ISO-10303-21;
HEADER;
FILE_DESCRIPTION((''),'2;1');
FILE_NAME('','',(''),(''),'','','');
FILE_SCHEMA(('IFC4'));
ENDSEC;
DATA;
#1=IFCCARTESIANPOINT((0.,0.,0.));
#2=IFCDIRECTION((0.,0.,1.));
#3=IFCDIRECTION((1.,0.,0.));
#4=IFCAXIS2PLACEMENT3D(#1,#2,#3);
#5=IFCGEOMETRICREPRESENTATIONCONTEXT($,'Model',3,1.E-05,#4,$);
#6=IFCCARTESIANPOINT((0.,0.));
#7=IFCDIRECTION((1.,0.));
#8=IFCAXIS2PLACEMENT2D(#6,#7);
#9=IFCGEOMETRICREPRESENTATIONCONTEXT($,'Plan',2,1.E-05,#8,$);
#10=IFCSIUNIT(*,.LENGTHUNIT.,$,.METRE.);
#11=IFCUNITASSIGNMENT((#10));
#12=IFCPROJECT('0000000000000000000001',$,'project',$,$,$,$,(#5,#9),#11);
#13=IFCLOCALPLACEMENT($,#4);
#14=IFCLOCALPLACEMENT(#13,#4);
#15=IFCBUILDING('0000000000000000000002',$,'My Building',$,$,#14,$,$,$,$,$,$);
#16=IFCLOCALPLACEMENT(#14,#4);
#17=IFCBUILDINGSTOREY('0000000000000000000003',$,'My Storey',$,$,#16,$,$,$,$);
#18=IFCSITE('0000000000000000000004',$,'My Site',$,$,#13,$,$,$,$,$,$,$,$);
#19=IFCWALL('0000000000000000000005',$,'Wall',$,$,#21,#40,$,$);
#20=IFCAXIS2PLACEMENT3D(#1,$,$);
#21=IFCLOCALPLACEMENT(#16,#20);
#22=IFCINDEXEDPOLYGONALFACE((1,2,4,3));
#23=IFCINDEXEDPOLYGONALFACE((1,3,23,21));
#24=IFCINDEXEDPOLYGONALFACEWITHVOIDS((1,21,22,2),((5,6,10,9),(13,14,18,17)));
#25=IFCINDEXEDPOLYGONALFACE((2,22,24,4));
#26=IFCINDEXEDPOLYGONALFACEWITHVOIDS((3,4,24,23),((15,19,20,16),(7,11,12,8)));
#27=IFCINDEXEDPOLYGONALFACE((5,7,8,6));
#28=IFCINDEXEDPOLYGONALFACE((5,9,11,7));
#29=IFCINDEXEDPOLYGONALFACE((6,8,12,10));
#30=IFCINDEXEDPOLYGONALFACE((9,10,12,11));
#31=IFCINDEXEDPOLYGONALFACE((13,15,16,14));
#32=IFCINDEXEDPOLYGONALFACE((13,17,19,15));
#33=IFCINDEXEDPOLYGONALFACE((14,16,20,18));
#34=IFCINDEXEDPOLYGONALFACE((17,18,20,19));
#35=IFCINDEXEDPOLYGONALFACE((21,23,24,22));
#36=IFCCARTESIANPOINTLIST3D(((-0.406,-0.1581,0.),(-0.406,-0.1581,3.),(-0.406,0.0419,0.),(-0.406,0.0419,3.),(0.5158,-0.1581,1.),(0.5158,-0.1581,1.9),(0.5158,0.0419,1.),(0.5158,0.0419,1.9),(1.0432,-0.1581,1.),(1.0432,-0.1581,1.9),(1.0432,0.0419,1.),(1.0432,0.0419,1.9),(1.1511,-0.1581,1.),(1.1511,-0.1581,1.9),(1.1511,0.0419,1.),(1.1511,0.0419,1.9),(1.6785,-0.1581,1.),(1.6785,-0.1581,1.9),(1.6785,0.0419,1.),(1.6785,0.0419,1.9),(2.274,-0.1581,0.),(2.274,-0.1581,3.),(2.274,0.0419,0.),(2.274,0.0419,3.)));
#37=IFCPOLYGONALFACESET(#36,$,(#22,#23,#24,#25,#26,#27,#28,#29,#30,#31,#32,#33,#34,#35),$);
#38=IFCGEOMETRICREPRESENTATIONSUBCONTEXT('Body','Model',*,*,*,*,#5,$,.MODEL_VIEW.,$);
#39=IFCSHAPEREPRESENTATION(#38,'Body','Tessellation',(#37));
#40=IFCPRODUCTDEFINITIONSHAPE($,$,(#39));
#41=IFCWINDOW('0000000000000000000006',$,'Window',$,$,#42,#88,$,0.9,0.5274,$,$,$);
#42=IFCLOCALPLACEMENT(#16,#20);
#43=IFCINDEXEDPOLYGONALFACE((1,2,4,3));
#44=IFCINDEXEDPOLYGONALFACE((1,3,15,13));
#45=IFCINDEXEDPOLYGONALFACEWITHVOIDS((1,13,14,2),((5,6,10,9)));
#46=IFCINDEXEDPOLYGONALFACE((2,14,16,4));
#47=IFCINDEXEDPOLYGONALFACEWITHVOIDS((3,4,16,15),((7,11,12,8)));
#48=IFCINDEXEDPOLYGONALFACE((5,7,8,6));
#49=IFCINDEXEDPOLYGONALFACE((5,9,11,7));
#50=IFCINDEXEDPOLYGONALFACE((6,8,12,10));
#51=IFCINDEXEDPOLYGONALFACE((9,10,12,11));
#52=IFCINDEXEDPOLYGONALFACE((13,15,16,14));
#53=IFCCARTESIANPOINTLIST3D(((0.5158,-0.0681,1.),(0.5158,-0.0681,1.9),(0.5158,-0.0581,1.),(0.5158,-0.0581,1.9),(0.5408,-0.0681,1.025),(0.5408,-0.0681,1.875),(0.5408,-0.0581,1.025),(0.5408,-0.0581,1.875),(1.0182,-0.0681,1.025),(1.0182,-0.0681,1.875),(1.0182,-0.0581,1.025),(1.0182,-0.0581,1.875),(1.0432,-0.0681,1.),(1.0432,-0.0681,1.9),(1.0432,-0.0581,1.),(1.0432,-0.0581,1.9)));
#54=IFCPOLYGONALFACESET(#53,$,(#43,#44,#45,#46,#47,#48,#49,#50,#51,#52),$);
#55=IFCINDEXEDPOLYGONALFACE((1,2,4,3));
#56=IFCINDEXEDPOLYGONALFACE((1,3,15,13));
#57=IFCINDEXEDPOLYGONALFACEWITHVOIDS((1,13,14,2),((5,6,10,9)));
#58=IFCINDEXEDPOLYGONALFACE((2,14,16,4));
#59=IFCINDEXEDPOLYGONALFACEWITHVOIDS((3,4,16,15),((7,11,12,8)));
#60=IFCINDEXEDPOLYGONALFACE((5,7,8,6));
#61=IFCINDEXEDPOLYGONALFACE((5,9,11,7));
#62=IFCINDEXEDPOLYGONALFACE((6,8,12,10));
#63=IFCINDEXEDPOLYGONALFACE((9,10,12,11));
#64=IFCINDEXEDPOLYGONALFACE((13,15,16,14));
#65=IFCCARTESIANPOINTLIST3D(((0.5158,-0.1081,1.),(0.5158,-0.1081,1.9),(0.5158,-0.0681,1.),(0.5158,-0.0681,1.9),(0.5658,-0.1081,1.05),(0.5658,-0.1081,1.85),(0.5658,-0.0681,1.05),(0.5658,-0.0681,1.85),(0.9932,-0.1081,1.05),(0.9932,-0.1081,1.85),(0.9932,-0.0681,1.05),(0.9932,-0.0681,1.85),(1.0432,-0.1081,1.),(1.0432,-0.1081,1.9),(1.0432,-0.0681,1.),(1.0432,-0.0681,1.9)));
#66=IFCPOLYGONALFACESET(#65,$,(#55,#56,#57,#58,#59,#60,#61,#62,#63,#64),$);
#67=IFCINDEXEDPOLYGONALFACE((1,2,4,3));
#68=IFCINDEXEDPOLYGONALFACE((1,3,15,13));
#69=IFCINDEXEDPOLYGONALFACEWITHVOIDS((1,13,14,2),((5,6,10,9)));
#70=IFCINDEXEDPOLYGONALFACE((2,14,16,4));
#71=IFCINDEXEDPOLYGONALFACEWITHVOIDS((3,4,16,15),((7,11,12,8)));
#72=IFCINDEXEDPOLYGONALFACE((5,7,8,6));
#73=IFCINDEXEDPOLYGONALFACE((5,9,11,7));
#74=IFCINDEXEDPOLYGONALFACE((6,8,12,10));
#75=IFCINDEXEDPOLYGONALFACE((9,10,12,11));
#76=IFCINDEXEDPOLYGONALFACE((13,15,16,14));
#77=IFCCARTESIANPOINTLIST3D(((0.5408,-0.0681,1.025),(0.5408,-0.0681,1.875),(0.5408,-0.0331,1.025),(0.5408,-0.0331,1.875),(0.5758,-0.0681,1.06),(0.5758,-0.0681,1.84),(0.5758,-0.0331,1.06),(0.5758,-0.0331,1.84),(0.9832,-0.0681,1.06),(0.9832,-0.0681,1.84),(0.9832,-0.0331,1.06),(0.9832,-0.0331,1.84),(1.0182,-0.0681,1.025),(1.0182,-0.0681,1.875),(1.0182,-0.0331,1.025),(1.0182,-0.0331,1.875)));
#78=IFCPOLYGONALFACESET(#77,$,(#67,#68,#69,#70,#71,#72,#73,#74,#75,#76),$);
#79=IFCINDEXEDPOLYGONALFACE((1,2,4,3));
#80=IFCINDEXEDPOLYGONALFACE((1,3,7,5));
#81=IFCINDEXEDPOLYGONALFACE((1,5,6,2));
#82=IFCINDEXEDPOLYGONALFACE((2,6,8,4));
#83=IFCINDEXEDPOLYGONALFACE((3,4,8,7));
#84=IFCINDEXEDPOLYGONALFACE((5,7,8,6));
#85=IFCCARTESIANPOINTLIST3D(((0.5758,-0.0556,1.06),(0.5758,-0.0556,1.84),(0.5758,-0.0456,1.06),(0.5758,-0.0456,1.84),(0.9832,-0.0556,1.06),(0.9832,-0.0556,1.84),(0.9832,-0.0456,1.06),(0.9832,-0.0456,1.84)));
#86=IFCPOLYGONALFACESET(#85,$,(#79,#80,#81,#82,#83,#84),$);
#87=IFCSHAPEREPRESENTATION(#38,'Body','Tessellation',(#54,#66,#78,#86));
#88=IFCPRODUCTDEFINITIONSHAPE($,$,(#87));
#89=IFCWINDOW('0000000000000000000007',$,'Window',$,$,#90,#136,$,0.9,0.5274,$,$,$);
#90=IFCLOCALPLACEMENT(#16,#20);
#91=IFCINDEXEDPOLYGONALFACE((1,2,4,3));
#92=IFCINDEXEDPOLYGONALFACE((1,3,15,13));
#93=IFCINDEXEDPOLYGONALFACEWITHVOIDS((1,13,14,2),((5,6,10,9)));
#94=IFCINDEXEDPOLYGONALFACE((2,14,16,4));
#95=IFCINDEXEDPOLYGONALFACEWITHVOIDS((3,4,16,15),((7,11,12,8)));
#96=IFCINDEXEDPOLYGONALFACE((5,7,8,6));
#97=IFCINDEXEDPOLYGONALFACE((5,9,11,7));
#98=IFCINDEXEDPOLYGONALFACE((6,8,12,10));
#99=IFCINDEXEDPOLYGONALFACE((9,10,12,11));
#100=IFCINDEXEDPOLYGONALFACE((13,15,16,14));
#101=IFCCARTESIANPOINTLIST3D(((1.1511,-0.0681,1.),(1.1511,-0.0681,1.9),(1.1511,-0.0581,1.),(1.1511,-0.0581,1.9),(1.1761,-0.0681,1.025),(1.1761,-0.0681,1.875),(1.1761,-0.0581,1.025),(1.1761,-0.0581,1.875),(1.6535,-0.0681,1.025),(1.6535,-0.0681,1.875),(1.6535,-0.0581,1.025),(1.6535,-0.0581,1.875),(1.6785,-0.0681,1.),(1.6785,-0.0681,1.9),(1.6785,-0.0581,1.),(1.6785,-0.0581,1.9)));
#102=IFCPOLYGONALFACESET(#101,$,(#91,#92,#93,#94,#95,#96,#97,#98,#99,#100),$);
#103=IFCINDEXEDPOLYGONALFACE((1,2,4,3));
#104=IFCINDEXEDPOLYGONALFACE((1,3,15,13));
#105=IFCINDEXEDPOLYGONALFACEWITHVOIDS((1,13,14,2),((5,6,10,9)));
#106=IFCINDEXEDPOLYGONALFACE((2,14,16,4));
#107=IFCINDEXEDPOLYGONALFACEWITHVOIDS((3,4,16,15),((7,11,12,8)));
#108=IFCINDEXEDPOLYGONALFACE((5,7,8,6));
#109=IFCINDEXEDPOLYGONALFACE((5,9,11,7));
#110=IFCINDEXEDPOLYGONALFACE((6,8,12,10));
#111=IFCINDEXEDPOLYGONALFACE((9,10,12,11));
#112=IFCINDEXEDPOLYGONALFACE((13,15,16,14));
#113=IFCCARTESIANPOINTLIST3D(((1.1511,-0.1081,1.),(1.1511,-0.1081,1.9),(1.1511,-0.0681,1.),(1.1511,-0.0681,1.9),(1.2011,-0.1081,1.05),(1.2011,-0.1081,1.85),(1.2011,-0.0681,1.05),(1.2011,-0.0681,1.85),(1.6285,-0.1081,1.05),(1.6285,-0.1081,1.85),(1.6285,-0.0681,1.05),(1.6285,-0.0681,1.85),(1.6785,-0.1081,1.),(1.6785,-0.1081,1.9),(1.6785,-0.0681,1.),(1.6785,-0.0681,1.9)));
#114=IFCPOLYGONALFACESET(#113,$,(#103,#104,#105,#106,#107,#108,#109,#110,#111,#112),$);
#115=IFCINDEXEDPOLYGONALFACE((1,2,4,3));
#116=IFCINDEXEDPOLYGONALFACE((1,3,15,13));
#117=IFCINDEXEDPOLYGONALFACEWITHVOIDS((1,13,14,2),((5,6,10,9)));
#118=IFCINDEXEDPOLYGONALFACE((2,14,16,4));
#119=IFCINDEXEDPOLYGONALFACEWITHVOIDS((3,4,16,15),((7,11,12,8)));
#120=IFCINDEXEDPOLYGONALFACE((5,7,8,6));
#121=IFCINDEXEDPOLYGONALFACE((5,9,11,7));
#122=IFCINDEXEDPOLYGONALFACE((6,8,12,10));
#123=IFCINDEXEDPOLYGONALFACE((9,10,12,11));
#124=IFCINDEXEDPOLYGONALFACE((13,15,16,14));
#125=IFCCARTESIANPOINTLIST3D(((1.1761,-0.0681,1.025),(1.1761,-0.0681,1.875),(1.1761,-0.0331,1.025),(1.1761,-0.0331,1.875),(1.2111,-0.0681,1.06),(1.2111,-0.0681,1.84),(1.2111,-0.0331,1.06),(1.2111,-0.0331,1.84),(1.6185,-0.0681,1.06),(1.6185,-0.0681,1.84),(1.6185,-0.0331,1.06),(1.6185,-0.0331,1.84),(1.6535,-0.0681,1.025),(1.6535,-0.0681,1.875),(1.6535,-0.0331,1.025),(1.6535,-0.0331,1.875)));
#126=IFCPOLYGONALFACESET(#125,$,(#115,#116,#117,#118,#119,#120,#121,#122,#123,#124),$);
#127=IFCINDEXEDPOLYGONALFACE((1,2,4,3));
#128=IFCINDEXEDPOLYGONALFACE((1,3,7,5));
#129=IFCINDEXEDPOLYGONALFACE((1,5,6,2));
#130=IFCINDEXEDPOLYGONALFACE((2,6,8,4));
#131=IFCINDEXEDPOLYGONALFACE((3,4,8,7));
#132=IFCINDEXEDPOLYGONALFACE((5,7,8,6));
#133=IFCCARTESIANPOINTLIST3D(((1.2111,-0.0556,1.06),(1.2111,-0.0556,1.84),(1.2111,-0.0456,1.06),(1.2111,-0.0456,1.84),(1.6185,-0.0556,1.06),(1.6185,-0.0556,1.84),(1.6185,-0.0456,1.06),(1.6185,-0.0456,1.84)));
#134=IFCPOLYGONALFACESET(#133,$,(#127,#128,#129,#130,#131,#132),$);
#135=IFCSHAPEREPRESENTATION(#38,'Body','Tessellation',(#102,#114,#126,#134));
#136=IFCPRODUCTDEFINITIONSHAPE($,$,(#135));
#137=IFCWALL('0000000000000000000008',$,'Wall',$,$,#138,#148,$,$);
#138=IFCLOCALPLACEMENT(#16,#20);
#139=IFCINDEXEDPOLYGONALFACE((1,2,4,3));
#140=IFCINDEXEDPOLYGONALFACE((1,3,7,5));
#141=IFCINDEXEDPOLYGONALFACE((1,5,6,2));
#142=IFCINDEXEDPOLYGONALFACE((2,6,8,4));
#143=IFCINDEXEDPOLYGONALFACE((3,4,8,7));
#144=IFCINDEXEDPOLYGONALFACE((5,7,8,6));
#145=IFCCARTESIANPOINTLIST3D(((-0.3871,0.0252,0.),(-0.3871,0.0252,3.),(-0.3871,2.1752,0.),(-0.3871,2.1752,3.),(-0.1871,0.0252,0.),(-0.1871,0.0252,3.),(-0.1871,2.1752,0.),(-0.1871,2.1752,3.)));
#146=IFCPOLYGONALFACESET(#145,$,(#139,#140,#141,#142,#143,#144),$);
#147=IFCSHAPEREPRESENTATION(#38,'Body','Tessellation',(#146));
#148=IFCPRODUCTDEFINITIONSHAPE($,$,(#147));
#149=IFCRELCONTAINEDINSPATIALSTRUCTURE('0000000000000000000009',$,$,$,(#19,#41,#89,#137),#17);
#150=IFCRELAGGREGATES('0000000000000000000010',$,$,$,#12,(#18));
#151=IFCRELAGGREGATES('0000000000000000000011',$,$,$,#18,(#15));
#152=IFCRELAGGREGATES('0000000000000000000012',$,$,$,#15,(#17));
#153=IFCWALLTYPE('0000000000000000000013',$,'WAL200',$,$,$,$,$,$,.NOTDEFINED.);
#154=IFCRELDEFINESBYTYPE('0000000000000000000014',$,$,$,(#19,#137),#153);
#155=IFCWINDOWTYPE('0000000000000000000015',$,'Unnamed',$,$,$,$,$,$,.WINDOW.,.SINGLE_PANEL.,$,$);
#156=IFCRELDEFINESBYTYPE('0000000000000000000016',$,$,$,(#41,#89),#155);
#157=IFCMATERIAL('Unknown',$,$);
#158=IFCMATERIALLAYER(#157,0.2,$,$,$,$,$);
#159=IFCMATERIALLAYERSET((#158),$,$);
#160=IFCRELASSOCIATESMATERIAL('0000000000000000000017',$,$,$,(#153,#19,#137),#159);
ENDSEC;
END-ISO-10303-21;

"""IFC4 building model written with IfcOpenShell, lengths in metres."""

from ifc_helpers import new_model, entity, si_unit, frame, origin_with_axes, origin_2d_with_axis, place, context, subcontext, project, spatial, line, indexed_curve, outline, extrude, shape, source, transform, mapped, material, layer, layer_set, layer_usage, type_object, type_shapes, element, fill, save


model = new_model("IFC4")

# Units and contexts
model_context = context("Model", 3, precision=1e-05, world=origin_with_axes())
plan_context = context("Plan", 2, precision=1e-05, world=origin_2d_with_axis())
body_context_1 = subcontext(model_context, "Body", "Model", "MODEL_VIEW")
body_context_2 = subcontext(plan_context, "Body", "Plan", "PLAN_VIEW")
ifc_project = project(units=[si_unit("LENGTHUNIT", "METRE")], contexts=[model_context, plan_context])

# Site, building, storey
site_placement = place(None, origin_with_axes())
site = spatial("IfcSite", under=ifc_project, at=site_placement, Name="My Site")
building_placement = place(site_placement, origin_with_axes())
building = spatial("IfcBuilding", under=site, at=building_placement, Name="My Building")
storey_placement = place(building_placement, origin_with_axes())
storey = spatial("IfcBuildingStorey", under=building, at=storey_placement, Name="My Storey")

# Shared definitions
ifc_material = material(Name="Unknown")

# Wall, openings, windows
ifc_layer_1 = layer(ifc_material, 0.2)
ifc_layer_set_1 = layer_set([ifc_layer_1])
ifc_layer_usage_1 = layer_usage(ifc_layer_set_1, "AXIS2", "POSITIVE", 0.0)
wall_type = type_object("IfcWallType", Name="WAL200", PredefinedType="NOTDEFINED", material=ifc_layer_set_1)
wall_1_placement = place(storey_placement, frame((2.274, 0.0419, 0.0), z_axis=(0.0, 0.0, 1.0), x_axis=(-1.0, 0.0, 0.0)))
wall_1 = element("IfcWall", 1, at=wall_1_placement, inside=storey, type_object=wall_type, material=ifc_layer_usage_1, Name="Wall", context=body_context_1, shape_type="SweptSolid", body=[
    extrude(outline(indexed_curve([(0.0, 0.0), (0.0, 0.2), (2.68, 0.2), (2.68, 0.0)], segments=[line(1, 2, 3, 4, 1)])), origin_with_axes(), (0.0, 0.0, 1.0), 3.0),
])
shared_shape_1 = source(origin_with_axes(), body_context_1, "Body", "SweptSolid", [
    extrude(outline(indexed_curve([(0.0, 0.0), (0.5274, 0.0), (0.5274, 0.9), (0.0, 0.9)], segments=[line(1, 2, 3, 4, 1)])), frame((0.0, -0.6, 0.0), z_axis=(0.0, -1.0, 0.0), x_axis=(1.0, 0.0, 0.0)), (0.0, 0.0, -1.0), 1.2),
])
opening_1_placement = place(wall_1_placement, frame((1.7582, 0.2, 1.0), z_axis=(0.0, 0.0, 1.0), x_axis=(-1.0, 0.0, 0.0)))
opening_1 = element("IfcOpeningElement", 2, at=opening_1_placement, cuts=wall_1, PredefinedType="OPENING", context=body_context_1, shape_type="MappedRepresentation", body=[
    mapped(shared_shape_1, transform((0.0, 0.0, 0.0), x_axis=(1.0, 0.0, 0.0), y_axis=(0.0, 1.0, 0.0), z_axis=(0.0, 0.0, 1.0), scale=1.0)),
])
opening_2_placement = place(wall_1_placement, frame((1.1229, 0.2, 1.0), z_axis=(0.0, 0.0, 1.0), x_axis=(-1.0, 0.0, 0.0)))
opening_2 = element("IfcOpeningElement", 3, at=opening_2_placement, cuts=wall_1, PredefinedType="OPENING", context=body_context_1, shape_type="MappedRepresentation", body=[
    mapped(shared_shape_1, transform((0.0, 0.0, 0.0), x_axis=(1.0, 0.0, 0.0), y_axis=(0.0, 1.0, 0.0), z_axis=(0.0, 0.0, 1.0), scale=1.0)),
])
window_type_1 = type_object("IfcWindowType", Name="Unnamed", PartitioningType="SINGLE_PANEL", PredefinedType="WINDOW")
shared_shape_2 = source(origin_with_axes(), body_context_1, "Body", "SweptSolid", [
    extrude(outline(indexed_curve([(0.0, 0.0), (0.5274, 0.0), (0.5274, 0.9), (0.0, 0.9)], segments=[line(1, 2, 3, 4, 1)]), holes=[indexed_curve([(0.025, 0.025), (0.5024, 0.025), (0.5024, 0.875), (0.025, 0.875)], segments=[line(1, 2, 3, 4, 1)])]), frame((0.0, 0.09, 0.0), z_axis=(0.0, -1.0, 0.0), x_axis=(1.0, 0.0, 0.0)), (0.0, 0.0, -1.0), 0.01),
    extrude(outline(indexed_curve([(0.0, 0.0), (0.5274, 0.0), (0.5274, 0.9), (0.0, 0.9)], segments=[line(1, 2, 3, 4, 1)]), holes=[indexed_curve([(0.05, 0.05), (0.4774, 0.05), (0.4774, 0.85), (0.05, 0.85)], segments=[line(1, 2, 3, 4, 1)])]), frame((0.0, 0.05, 0.0), z_axis=(0.0, -1.0, 0.0), x_axis=(1.0, 0.0, 0.0)), (0.0, 0.0, -1.0), 0.04),
    extrude(outline(indexed_curve([(0.0, 0.0), (0.4774, 0.0), (0.4774, 0.85), (0.0, 0.85)], segments=[line(1, 2, 3, 4, 1)]), holes=[indexed_curve([(0.035, 0.035), (0.4424, 0.035), (0.4424, 0.815), (0.035, 0.815)], segments=[line(1, 2, 3, 4, 1)])]), frame((0.025, 0.09, 0.025), z_axis=(0.0, -1.0, 0.0), x_axis=(1.0, 0.0, 0.0)), (0.0, 0.0, -1.0), 0.035),
    extrude(outline(indexed_curve([(0.035, 0.035), (0.4424, 0.035), (0.4424, 0.815), (0.035, 0.815)], segments=[line(1, 2, 3, 4, 1)])), frame((0.025, 0.1025, 0.025), z_axis=(0.0, -1.0, 0.0), x_axis=(1.0, 0.0, 0.0)), (0.0, 0.0, -1.0), 0.01),
])
shared_shape_3 = source(origin_with_axes(), body_context_2, "Body", "Curve2D", [
    entity("IfcIndexedPolyCurve", entity("IfcCartesianPointList2D", [[0.05, 0.05], [0.4774, 0.05]])),
    entity("IfcIndexedPolyCurve", entity("IfcCartesianPointList2D", [[0.0, 0.1], [0.025, 0.1], [0.025, 0.09], [0.05, 0.09], [0.05, 0.05], [0.0, 0.05]]), [entity("IfcLineIndex", [1, 2, 3, 4, 5, 6, 1])]),
    entity("IfcIndexedPolyCurve", entity("IfcCartesianPointList2D", [[0.5274, 0.1], [0.5024, 0.1], [0.5024, 0.09], [0.4774, 0.09], [0.4774, 0.05], [0.5274, 0.05]]), [entity("IfcLineIndex", [1, 2, 3, 4, 5, 6, 1])]),
    entity("IfcIndexedPolyCurve", entity("IfcCartesianPointList2D", [[0.025, 0.09], [0.06, 0.09], [0.06, 0.125], [0.025, 0.125]]), [entity("IfcLineIndex", [1, 2, 3, 4, 1])]),
    entity("IfcIndexedPolyCurve", entity("IfcCartesianPointList2D", [[0.5024, 0.09], [0.4674, 0.09], [0.4674, 0.125], [0.5024, 0.125]]), [entity("IfcLineIndex", [1, 2, 3, 4, 1])]),
    entity("IfcIndexedPolyCurve", entity("IfcCartesianPointList2D", [[0.06, 0.09], [0.4674, 0.09]])),
    entity("IfcIndexedPolyCurve", entity("IfcCartesianPointList2D", [[0.06, 0.125], [0.4674, 0.125]])),
    entity("IfcIndexedPolyCurve", entity("IfcCartesianPointList2D", [[0.06, 0.1075], [0.4674, 0.1075]])),
])
type_shapes(window_type_1, [shared_shape_2, shared_shape_3])
window_1_placement = place(opening_1_placement, frame((0.0, 0.0, 0.0), z_axis=(0.0, 0.0, 1.0), x_axis=(1.0, 0.0, 0.0)))
window_1 = element("IfcWindow", 4, at=window_1_placement, inside=storey, type_object=window_type_1, Name="Window", OverallHeight=0.9, OverallWidth=0.5274, shapes=[
    shape(body_context_1, "Body", "MappedRepresentation", [mapped(shared_shape_2, transform((0.0, 0.0, 0.0), x_axis=(1.0, 0.0, 0.0), y_axis=(0.0, 1.0, 0.0), z_axis=(0.0, 0.0, 1.0), scale=1.0))]),
    shape(body_context_2, "Body", "MappedRepresentation", [mapped(shared_shape_3, transform((0.0, 0.0, 0.0), x_axis=(1.0, 0.0, 0.0), y_axis=(0.0, 1.0, 0.0), z_axis=(0.0, 0.0, 1.0), scale=1.0))]),
])
fill(opening_1, window_1)
window_2_placement = place(opening_2_placement, frame((0.0, 0.0, 0.0), z_axis=(0.0, 0.0, 1.0), x_axis=(1.0, 0.0, 0.0)))
window_2 = element("IfcWindow", 5, at=window_2_placement, inside=storey, type_object=window_type_1, Name="Window", OverallHeight=0.9, OverallWidth=0.5274, shapes=[
    shape(body_context_1, "Body", "MappedRepresentation", [mapped(shared_shape_2, transform((0.0, 0.0, 0.0), x_axis=(1.0, 0.0, 0.0), y_axis=(0.0, 1.0, 0.0), z_axis=(0.0, 0.0, 1.0), scale=1.0))]),
    shape(body_context_2, "Body", "MappedRepresentation", [mapped(shared_shape_3, transform((0.0, 0.0, 0.0), x_axis=(1.0, 0.0, 0.0), y_axis=(0.0, 1.0, 0.0), z_axis=(0.0, 0.0, 1.0), scale=1.0))]),
])
fill(opening_2, window_2)

# Wall
ifc_layer_usage_2 = layer_usage(ifc_layer_set_1, "AXIS2", "POSITIVE", 0.0)
wall_2_placement = place(storey_placement, frame((-0.1871, 0.0252, 0.0), z_axis=(0.0, 0.0, 1.0), x_axis=(0.0, 1.0, 0.0)))
element("IfcWall", 6, at=wall_2_placement, inside=storey, type_object=wall_type, material=ifc_layer_usage_2, Name="Wall", context=body_context_1, shape_type="SweptSolid", body=[
    extrude(outline(indexed_curve([(0.0, 0.0), (0.0, 0.2), (2.15, 0.2), (2.15, 0.0)], segments=[line(1, 2, 3, 4, 1)])), origin_with_axes(), (0.0, 0.0, 1.0), 3.0),
])

save(model, "model.ifc")
